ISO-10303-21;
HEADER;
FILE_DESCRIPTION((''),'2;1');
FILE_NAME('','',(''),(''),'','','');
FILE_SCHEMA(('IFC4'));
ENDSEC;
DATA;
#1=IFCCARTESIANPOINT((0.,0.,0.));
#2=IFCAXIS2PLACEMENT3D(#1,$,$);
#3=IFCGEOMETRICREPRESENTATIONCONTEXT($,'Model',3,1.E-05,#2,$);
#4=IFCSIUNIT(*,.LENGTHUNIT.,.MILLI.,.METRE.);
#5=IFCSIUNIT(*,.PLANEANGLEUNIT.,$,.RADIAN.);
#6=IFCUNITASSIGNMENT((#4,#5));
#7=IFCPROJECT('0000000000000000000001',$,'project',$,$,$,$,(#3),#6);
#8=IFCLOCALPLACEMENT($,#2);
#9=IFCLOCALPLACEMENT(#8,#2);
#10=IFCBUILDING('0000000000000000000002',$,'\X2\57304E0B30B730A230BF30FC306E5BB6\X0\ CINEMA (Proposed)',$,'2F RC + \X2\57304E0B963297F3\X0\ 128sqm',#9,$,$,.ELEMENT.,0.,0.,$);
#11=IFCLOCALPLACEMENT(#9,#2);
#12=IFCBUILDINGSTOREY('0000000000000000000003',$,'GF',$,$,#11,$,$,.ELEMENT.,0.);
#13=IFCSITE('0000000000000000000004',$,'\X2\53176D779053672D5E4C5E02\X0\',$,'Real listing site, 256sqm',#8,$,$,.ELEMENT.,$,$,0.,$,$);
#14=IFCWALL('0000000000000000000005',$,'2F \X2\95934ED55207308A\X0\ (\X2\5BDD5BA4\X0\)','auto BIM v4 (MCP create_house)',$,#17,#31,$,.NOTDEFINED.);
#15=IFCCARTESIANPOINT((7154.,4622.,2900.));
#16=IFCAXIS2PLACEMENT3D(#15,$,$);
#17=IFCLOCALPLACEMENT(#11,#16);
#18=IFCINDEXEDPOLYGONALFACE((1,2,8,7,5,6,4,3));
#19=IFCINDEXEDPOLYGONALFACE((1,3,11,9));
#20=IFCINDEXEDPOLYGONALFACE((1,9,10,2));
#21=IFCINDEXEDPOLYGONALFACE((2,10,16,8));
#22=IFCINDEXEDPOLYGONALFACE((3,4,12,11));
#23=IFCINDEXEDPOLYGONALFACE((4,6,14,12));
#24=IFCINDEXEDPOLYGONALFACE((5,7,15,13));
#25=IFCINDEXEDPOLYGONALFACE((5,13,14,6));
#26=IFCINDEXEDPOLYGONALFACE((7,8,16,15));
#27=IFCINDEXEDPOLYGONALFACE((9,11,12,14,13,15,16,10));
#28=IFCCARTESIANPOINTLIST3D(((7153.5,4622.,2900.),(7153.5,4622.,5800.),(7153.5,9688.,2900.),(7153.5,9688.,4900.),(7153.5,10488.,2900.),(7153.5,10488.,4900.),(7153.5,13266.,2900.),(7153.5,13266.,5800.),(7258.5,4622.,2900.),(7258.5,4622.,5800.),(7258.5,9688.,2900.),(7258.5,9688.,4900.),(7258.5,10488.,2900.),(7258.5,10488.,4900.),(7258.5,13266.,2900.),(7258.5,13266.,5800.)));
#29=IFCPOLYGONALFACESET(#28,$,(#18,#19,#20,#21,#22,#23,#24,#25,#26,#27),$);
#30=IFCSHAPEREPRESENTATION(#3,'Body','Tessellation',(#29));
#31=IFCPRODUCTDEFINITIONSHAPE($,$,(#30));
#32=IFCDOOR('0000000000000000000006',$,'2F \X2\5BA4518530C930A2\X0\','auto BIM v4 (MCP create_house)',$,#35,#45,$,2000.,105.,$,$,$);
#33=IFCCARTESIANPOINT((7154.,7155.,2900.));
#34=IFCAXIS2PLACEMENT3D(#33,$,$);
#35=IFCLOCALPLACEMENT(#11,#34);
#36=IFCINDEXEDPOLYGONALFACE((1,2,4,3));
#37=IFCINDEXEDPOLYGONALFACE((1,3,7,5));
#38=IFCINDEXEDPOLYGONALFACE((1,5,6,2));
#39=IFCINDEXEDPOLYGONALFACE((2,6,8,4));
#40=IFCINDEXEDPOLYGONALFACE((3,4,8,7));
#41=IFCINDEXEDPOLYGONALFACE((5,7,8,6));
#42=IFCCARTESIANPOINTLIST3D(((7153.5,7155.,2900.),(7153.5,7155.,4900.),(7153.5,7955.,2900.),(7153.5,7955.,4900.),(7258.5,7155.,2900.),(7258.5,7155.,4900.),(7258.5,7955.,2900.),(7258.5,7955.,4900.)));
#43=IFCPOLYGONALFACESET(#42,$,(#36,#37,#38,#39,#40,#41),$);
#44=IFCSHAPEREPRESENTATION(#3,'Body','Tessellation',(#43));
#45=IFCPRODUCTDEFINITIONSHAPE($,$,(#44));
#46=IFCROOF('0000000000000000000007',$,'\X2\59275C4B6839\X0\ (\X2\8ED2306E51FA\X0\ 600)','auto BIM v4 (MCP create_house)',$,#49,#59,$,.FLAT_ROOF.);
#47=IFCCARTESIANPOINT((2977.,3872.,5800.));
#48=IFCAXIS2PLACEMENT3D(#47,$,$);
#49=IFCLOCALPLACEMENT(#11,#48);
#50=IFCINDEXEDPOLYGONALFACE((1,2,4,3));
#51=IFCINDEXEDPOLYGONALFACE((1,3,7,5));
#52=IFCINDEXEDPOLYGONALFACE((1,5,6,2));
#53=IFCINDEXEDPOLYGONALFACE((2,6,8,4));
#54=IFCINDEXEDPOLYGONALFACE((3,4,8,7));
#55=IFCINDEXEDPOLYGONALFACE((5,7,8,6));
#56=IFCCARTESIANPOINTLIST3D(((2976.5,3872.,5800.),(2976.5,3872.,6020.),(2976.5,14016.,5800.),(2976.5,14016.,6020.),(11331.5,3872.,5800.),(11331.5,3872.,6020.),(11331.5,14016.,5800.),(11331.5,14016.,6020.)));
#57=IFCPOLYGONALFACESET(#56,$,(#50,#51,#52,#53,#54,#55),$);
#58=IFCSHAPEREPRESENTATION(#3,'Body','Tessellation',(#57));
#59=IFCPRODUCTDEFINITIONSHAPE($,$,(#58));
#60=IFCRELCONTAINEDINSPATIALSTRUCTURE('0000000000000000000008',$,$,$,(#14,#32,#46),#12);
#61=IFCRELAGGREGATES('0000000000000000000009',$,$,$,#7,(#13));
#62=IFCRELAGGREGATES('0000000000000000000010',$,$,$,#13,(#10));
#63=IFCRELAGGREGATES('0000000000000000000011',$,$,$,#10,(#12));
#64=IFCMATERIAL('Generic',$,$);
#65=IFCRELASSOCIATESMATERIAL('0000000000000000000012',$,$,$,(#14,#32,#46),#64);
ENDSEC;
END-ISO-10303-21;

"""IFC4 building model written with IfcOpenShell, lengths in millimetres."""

from ifc_helpers import new_model, si_unit, frame, frame_2d, origin, place, context, project, spatial, rectangle, extrude, material, element, fill, save


model = new_model("IFC4")

# Units and contexts
model_context = context("Model", 3, precision=1e-05, world=origin())
ifc_project = project(units=[si_unit("LENGTHUNIT", "METRE", prefix="MILLI"), si_unit("PLANEANGLEUNIT", "RADIAN")], contexts=[model_context])

# Site, building, storey
site_placement = place(None, origin())
site = spatial("IfcSite", under=ifc_project, at=site_placement, Name="北海道札幌市", ObjectType="Real listing site, 256sqm", CompositionType="ELEMENT", RefElevation=0.0)
building_placement = place(site_placement, origin())
building = spatial("IfcBuilding", under=site, at=building_placement, Name="地下シアターの家 CINEMA (Proposed)", ObjectType="2F RC + 地下防音 128sqm", CompositionType="ELEMENT", ElevationOfRefHeight=0.0, ElevationOfTerrain=0.0)
storey_placement = place(building_placement, origin())
storey = spatial("IfcBuildingStorey", under=building, at=storey_placement, Name="GF", CompositionType="ELEMENT", Elevation=0.0)

# Shared definitions
ifc_material = material(Name="Generic")

# Wall, opening, door
wall_1_placement = place(storey_placement, frame((7154.0, 4622.0, 2900.0)))
wall_1 = element("IfcWall", 1, at=wall_1_placement, inside=storey, material=ifc_material, Name="2F 間仕切り (寝室)", Description="auto BIM v4 (MCP create_house)", PredefinedType="NOTDEFINED", context=model_context, shape_type="SweptSolid", body=[
    extrude(rectangle(XDim=105.0, YDim=8644.0, at=frame_2d((52.0, 4322.0))), frame((7154.0, 4622.0, 2900.0)), (0.0, 0.0, 1.0), 2900.0),
])
opening_1_placement = place(storey_placement, frame((7154.0, 7155.0, 2900.0)))
opening_1 = element("IfcOpeningElement", 2, at=opening_1_placement, cuts=wall_1, PredefinedType="NOTDEFINED", context=model_context, shape_type="SweptSolid", body=[
    extrude(rectangle(XDim=105.0, YDim=800.0, at=frame_2d((52.0, 400.0))), frame((7154.0, 7155.0, 2900.0)), (0.0, 0.0, 1.0), 2000.0),
])
door_1_placement = place(storey_placement, frame((7154.0, 7155.0, 2900.0)))
door_1 = element("IfcDoor", 3, at=door_1_placement, inside=storey, material=ifc_material, Name="2F 室内ドア", Description="auto BIM v4 (MCP create_house)", OverallHeight=2000.0, OverallWidth=105.0, context=model_context, shape_type="SweptSolid", body=[
    extrude(rectangle(XDim=105.0, YDim=800.0, at=frame_2d((52.0, 400.0))), frame((7154.0, 7155.0, 2900.0)), (0.0, 0.0, 1.0), 2000.0),
])
fill(opening_1, door_1)

# Roof
roof_placement = place(storey_placement, frame((2977.0, 3872.0, 5800.0)))
element("IfcRoof", 4, at=roof_placement, inside=storey, material=ifc_material, Name="大屋根 (軒の出 600)", Description="auto BIM v4 (MCP create_house)", PredefinedType="FLAT_ROOF", context=model_context, shape_type="SweptSolid", body=[
    extrude(rectangle(XDim=8355.0, YDim=10144.0, at=frame_2d((4177.0, 5072.0))), frame((2977.0, 3872.0, 5800.0)), (0.0, 0.0, 1.0), 220.0),
])

save(model, "model.ifc")
